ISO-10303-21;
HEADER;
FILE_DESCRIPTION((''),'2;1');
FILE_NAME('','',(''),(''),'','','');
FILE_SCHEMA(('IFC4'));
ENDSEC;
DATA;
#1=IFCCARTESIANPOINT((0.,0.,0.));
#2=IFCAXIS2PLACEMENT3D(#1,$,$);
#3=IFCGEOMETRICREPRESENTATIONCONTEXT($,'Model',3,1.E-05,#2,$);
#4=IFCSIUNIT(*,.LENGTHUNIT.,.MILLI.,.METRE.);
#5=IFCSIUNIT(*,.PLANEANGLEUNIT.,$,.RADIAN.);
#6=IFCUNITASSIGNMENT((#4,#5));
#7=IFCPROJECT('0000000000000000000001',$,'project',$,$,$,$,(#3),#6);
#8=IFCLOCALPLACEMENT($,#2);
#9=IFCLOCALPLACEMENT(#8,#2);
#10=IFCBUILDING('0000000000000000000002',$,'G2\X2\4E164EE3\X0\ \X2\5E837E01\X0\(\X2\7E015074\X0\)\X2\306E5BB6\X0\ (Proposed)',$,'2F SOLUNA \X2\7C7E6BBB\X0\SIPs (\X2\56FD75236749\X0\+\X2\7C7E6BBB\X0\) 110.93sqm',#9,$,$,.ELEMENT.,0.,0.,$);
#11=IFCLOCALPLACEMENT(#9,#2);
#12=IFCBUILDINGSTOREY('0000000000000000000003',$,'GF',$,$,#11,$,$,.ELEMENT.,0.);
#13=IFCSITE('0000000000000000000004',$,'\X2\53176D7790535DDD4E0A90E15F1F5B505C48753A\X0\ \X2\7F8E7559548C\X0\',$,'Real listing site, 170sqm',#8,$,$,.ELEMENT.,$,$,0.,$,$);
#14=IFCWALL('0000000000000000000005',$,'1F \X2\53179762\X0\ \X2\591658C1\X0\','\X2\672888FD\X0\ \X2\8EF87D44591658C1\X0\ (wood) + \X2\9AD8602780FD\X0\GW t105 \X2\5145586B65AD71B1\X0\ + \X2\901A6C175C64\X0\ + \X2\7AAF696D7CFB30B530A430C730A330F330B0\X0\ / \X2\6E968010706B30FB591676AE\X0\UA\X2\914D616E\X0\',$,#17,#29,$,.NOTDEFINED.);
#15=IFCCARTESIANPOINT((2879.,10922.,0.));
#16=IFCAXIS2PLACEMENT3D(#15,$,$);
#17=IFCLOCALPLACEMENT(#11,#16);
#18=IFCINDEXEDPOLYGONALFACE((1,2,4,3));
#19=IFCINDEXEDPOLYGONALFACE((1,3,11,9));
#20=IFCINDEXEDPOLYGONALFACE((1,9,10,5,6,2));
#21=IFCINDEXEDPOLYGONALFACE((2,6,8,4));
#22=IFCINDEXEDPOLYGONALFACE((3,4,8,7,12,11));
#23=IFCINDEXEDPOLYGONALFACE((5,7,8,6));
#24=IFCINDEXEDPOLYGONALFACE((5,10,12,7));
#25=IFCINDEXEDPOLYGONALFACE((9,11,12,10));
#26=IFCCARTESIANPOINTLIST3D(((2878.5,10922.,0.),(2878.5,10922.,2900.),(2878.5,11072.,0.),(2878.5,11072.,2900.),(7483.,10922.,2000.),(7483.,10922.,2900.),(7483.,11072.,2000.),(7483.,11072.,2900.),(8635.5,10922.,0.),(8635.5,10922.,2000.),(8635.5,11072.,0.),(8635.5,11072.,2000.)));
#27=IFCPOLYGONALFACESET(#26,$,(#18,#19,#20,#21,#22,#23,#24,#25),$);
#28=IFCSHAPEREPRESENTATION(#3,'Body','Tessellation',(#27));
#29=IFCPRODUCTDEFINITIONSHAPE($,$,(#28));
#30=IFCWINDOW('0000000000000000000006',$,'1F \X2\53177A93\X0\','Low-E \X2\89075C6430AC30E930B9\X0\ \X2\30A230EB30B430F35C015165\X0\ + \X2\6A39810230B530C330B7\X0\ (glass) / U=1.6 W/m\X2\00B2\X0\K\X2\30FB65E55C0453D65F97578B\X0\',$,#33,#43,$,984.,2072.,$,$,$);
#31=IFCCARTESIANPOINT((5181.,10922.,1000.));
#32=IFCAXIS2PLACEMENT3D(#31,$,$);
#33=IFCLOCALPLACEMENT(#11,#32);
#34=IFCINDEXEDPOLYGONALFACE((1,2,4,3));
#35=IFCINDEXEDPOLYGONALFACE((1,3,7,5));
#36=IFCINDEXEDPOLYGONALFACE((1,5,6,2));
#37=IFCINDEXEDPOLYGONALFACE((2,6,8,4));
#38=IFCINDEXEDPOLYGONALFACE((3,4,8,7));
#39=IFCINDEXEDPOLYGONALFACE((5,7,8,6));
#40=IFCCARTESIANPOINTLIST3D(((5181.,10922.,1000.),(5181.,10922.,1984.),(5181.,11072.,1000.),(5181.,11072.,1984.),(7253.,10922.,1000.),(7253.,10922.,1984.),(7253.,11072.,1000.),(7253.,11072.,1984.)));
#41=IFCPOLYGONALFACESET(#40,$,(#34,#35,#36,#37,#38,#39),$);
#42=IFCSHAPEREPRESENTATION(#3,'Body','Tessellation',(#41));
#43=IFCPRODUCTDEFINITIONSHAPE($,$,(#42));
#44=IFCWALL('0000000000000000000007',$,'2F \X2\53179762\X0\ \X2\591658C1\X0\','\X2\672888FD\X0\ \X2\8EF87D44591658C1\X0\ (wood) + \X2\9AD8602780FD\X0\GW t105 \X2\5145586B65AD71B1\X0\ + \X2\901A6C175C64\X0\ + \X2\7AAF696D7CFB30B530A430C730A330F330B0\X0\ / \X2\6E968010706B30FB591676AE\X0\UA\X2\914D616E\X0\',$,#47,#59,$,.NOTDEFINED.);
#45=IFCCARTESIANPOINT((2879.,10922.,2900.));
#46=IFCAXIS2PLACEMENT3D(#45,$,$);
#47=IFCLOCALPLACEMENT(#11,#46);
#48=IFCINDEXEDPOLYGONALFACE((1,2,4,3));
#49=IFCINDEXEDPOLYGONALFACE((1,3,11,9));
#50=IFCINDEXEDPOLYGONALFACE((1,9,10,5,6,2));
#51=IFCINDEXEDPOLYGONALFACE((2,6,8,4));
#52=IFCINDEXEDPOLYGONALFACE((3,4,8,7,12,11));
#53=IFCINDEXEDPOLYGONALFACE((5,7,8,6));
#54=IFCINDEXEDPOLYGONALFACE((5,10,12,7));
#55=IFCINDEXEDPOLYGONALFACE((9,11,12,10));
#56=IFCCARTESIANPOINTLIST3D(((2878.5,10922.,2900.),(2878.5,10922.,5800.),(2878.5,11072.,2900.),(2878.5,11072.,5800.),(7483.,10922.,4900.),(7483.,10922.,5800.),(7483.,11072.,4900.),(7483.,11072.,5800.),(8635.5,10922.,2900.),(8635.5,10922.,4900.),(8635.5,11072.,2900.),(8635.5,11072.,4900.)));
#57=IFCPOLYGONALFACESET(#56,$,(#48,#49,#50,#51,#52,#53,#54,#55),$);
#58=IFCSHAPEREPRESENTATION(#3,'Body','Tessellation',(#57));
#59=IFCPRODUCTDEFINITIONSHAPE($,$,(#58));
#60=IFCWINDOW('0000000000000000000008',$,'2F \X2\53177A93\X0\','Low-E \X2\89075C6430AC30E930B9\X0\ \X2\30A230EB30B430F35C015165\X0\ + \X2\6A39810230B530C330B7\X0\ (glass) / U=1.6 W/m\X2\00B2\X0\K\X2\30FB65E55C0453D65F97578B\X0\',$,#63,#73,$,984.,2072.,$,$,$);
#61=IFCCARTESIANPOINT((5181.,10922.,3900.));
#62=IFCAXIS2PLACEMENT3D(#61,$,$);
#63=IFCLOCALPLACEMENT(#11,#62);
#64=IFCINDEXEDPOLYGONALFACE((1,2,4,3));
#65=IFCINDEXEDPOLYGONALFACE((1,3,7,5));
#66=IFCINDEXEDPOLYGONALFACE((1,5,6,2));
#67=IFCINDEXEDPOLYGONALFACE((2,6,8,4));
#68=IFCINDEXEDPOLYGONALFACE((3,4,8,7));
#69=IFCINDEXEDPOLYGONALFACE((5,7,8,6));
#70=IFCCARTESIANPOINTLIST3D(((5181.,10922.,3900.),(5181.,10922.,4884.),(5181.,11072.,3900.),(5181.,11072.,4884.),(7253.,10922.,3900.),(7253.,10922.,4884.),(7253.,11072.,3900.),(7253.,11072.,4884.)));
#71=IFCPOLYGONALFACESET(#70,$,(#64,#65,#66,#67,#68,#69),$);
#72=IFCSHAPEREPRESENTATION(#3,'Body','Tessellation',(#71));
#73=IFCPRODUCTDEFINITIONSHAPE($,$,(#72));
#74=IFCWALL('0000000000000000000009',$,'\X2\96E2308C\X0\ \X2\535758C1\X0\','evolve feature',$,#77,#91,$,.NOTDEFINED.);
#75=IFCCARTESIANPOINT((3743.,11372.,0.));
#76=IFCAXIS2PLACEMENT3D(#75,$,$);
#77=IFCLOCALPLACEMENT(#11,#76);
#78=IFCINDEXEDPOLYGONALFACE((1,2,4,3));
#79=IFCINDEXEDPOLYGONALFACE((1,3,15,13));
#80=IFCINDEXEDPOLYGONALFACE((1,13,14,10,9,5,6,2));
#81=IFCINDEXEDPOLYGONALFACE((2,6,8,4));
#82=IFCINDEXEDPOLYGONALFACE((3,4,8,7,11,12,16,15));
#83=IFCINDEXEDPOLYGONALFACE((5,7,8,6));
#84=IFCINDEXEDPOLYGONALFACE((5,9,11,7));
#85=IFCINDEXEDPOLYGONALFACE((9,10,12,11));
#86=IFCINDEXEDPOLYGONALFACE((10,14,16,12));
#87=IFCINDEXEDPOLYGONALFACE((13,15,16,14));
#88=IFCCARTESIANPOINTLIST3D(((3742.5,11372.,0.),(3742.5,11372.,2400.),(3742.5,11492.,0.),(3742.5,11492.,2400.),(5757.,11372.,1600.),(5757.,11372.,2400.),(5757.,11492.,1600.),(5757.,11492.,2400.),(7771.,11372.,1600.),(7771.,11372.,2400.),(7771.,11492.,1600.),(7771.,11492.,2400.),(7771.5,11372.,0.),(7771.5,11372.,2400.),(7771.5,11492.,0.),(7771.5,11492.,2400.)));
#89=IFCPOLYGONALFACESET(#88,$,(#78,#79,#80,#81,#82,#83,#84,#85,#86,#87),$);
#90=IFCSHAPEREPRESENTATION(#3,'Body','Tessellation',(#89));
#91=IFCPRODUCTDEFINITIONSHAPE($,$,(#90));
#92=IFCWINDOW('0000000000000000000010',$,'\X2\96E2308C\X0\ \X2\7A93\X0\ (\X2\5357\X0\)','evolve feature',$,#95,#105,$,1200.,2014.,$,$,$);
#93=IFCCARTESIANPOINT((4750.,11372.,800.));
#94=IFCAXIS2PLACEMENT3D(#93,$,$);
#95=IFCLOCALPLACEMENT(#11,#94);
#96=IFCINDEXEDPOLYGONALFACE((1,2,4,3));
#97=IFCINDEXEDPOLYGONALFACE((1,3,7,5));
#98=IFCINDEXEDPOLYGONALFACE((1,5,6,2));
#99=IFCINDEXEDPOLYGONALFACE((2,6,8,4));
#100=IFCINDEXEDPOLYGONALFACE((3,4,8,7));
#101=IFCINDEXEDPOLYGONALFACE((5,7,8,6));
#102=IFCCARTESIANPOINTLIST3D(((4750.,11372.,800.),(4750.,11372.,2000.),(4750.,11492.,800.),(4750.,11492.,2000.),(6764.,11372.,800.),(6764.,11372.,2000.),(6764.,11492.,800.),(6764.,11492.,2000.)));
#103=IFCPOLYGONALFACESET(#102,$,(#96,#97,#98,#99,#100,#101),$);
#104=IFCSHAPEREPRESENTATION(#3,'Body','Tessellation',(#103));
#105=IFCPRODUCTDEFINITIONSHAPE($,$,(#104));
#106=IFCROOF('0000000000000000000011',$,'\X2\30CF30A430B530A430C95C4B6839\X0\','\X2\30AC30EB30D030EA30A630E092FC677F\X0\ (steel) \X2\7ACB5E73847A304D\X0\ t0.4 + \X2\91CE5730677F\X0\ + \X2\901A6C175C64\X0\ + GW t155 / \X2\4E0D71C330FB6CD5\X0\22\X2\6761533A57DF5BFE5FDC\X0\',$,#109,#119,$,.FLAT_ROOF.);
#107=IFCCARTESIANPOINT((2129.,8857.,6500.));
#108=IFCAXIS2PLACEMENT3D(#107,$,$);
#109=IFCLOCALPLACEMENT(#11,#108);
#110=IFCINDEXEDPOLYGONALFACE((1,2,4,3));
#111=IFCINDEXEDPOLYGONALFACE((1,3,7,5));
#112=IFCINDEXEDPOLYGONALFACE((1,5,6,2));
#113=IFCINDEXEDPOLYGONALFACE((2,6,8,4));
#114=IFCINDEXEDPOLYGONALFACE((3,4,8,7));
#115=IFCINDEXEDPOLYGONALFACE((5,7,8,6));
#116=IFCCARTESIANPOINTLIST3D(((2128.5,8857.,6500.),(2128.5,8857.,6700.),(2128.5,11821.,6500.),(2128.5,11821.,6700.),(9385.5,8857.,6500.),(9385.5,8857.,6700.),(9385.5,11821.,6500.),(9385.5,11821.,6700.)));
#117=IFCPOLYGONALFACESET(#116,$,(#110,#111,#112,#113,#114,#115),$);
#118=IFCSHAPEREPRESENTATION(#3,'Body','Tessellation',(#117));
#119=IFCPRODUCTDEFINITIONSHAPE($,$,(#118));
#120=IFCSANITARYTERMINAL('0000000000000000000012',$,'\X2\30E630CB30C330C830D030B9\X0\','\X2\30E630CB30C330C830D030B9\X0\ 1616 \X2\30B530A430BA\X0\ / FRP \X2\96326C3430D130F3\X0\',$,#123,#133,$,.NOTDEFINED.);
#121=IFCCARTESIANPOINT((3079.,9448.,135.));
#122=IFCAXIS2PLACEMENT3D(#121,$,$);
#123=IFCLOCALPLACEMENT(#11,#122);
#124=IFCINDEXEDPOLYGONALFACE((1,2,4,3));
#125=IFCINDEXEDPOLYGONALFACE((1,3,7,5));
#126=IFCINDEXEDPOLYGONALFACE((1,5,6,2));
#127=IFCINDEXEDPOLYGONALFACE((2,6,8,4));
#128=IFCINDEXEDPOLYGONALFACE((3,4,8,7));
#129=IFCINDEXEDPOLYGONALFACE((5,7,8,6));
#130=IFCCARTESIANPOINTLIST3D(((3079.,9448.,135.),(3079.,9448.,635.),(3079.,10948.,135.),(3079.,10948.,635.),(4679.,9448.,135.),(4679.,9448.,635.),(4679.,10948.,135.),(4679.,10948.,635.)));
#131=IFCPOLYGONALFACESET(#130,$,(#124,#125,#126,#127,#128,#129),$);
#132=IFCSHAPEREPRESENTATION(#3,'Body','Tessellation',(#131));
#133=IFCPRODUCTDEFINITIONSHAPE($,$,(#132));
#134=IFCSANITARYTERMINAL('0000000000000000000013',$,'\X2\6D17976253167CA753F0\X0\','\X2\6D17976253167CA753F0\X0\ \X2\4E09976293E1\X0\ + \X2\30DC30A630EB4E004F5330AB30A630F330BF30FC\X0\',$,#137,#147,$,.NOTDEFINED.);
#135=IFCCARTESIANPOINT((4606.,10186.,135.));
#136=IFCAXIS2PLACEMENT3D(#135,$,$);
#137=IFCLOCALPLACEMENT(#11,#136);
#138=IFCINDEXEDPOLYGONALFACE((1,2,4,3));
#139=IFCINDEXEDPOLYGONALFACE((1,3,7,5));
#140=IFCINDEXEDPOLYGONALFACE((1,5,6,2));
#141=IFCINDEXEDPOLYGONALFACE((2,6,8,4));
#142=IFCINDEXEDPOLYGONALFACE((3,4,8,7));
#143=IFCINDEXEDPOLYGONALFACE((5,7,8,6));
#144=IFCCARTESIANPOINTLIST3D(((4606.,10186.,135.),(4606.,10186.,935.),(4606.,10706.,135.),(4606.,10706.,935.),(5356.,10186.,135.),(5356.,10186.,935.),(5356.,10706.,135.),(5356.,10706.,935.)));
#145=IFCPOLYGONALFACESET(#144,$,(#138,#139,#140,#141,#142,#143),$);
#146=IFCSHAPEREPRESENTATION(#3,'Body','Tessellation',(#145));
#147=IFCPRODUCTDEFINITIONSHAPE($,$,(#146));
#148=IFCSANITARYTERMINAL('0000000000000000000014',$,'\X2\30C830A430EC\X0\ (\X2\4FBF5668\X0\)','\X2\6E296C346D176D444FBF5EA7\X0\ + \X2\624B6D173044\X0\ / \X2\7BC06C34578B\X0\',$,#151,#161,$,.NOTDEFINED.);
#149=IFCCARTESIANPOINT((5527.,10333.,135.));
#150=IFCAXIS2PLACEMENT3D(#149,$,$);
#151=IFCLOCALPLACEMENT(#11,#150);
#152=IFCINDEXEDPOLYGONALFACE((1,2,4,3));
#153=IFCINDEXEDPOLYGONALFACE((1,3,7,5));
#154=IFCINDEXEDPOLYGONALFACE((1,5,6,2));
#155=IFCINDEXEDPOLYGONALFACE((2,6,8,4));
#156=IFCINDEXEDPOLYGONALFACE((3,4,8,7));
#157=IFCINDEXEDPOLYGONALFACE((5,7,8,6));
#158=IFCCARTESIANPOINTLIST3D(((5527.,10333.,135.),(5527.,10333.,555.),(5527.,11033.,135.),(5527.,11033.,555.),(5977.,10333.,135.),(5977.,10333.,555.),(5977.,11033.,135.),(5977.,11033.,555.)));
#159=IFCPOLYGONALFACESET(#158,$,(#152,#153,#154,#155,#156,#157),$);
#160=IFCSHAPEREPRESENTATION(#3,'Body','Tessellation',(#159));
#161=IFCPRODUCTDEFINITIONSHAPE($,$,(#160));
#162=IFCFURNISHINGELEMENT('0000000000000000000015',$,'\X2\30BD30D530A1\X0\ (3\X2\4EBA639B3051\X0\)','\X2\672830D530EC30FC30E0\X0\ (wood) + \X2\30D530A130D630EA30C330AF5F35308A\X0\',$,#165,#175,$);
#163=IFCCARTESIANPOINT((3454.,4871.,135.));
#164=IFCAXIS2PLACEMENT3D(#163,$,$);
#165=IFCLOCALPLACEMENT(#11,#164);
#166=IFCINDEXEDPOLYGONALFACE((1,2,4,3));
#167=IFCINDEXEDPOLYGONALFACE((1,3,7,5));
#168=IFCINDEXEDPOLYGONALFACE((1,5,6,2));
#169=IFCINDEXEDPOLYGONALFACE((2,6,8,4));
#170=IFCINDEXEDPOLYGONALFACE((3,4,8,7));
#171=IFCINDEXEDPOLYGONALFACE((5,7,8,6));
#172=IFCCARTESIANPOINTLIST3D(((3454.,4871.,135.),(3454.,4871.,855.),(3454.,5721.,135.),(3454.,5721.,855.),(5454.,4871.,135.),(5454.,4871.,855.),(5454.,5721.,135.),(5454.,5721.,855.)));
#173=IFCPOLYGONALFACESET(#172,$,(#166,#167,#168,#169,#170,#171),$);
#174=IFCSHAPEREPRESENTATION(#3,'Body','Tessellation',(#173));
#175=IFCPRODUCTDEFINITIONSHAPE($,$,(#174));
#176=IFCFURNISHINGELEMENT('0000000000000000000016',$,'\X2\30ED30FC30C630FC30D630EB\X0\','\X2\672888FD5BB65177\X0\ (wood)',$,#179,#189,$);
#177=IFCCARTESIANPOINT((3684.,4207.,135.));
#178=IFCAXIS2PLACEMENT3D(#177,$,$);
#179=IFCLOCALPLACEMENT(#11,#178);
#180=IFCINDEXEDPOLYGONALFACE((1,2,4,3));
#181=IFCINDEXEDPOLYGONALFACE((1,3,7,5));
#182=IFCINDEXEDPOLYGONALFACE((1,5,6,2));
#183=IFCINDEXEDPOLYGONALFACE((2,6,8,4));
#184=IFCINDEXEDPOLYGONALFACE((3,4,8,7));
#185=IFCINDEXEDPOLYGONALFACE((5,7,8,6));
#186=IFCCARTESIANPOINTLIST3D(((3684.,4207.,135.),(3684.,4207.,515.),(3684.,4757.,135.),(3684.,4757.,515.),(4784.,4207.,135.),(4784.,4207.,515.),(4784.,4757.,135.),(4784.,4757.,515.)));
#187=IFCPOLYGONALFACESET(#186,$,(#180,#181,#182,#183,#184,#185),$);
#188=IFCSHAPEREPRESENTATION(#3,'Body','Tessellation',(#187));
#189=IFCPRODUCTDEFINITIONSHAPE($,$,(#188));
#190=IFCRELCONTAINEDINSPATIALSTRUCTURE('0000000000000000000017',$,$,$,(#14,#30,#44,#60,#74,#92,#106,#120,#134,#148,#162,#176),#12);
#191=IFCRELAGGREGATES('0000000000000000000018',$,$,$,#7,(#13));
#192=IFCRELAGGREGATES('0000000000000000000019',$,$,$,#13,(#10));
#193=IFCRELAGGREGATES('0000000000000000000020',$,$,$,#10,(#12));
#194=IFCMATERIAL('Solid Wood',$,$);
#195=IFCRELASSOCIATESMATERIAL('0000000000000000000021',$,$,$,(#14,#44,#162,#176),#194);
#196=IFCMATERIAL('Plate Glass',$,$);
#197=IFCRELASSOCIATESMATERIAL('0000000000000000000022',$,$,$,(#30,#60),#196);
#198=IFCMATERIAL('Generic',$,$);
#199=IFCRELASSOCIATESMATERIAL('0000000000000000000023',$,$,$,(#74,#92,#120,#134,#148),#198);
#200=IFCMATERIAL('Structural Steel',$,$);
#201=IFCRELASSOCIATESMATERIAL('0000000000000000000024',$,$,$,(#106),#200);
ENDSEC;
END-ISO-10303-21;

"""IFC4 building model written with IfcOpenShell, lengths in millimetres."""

from ifc_helpers import new_model, si_unit, frame, frame_2d, origin, place, context, project, spatial, rectangle, extrude, material, element, fill, save


model = new_model("IFC4")

# Units and contexts
model_context = context("Model", 3, precision=1e-05, world=origin())
ifc_project = project(units=[si_unit("LENGTHUNIT", "METRE", prefix="MILLI"), si_unit("PLANEANGLEUNIT", "RADIAN")], contexts=[model_context])

# Site, building, storey
site_placement = place(None, origin())
site = spatial("IfcSite", under=ifc_project, at=site_placement, Name="北海道川上郡弟子屈町 美留和", ObjectType="Real listing site, 170sqm", CompositionType="ELEMENT", RefElevation=0.0)
building_placement = place(site_placement, origin())
building = spatial("IfcBuilding", under=site, at=building_placement, Name="G2世代 広縁(縁側)の家 (Proposed)", ObjectType="2F SOLUNA 籾殻SIPs (国産杉+籾殻) 110.93sqm", CompositionType="ELEMENT", ElevationOfRefHeight=0.0, ElevationOfTerrain=0.0)
storey_placement = place(building_placement, origin())
storey = spatial("IfcBuildingStorey", under=building, at=storey_placement, Name="GF", CompositionType="ELEMENT", Elevation=0.0)

# Shared definitions
ifc_material_1 = material(Name="Generic")

# Wall, opening, window
ifc_material_2 = material(Name="Solid Wood")
wall_1_placement = place(storey_placement, frame((2879.0, 10922.0, 0.0)))
wall_1 = element("IfcWall", 1, at=wall_1_placement, inside=storey, material=ifc_material_2, Name="1F 北面 外壁", Description="木製 軸組外壁 (wood) + 高性能GW t105 充填断熱 + 通気層 + 窯業系サイディング / 準耐火・外皮UA配慮", PredefinedType="NOTDEFINED", context=model_context, shape_type="SweptSolid", body=[
    extrude(rectangle(XDim=5757.0, YDim=150.0, at=frame_2d((2878.0, 75.0))), frame((2879.0, 10922.0, 0.0)), (0.0, 0.0, 1.0), 2900.0),
])
opening_1_placement = place(storey_placement, frame((5181.0, 10922.0, 1000.0)))
opening_1 = element("IfcOpeningElement", 2, at=opening_1_placement, cuts=wall_1, PredefinedType="NOTDEFINED", context=model_context, shape_type="SweptSolid", body=[
    extrude(rectangle(XDim=2072.0, YDim=150.0, at=frame_2d((1036.0, 75.0))), frame((5181.0, 10922.0, 1000.0)), (0.0, 0.0, 1.0), 984.0),
])
ifc_material_3 = material(Name="Plate Glass")
window_1_placement = place(storey_placement, frame((5181.0, 10922.0, 1000.0)))
window_1 = element("IfcWindow", 3, at=window_1_placement, inside=storey, material=ifc_material_3, Name="1F 北窓", Description="Low-E 複層ガラス アルゴン封入 + 樹脂サッシ (glass) / U=1.6 W/m²K・日射取得型", OverallHeight=984.0, OverallWidth=2072.0, context=model_context, shape_type="SweptSolid", body=[
    extrude(rectangle(XDim=2072.0, YDim=150.0, at=frame_2d((1036.0, 75.0))), frame((5181.0, 10922.0, 1000.0)), (0.0, 0.0, 1.0), 984.0),
])
fill(opening_1, window_1)

# Wall, opening, window
wall_2_placement = place(storey_placement, frame((2879.0, 10922.0, 2900.0)))
wall_2 = element("IfcWall", 4, at=wall_2_placement, inside=storey, material=ifc_material_2, Name="2F 北面 外壁", Description="木製 軸組外壁 (wood) + 高性能GW t105 充填断熱 + 通気層 + 窯業系サイディング / 準耐火・外皮UA配慮", PredefinedType="NOTDEFINED", context=model_context, shape_type="SweptSolid", body=[
    extrude(rectangle(XDim=5757.0, YDim=150.0, at=frame_2d((2878.0, 75.0))), frame((2879.0, 10922.0, 2900.0)), (0.0, 0.0, 1.0), 2900.0),
])
opening_2_placement = place(storey_placement, frame((5181.0, 10922.0, 3900.0)))
opening_2 = element("IfcOpeningElement", 5, at=opening_2_placement, cuts=wall_2, PredefinedType="NOTDEFINED", context=model_context, shape_type="SweptSolid", body=[
    extrude(rectangle(XDim=2072.0, YDim=150.0, at=frame_2d((1036.0, 75.0))), frame((5181.0, 10922.0, 3900.0)), (0.0, 0.0, 1.0), 984.0),
])
window_2_placement = place(storey_placement, frame((5181.0, 10922.0, 3900.0)))
window_2 = element("IfcWindow", 6, at=window_2_placement, inside=storey, material=ifc_material_3, Name="2F 北窓", Description="Low-E 複層ガラス アルゴン封入 + 樹脂サッシ (glass) / U=1.6 W/m²K・日射取得型", OverallHeight=984.0, OverallWidth=2072.0, context=model_context, shape_type="SweptSolid", body=[
    extrude(rectangle(XDim=2072.0, YDim=150.0, at=frame_2d((1036.0, 75.0))), frame((5181.0, 10922.0, 3900.0)), (0.0, 0.0, 1.0), 984.0),
])
fill(opening_2, window_2)

# Wall, opening, window
wall_3_placement = place(storey_placement, frame((3743.0, 11372.0, 0.0)))
wall_3 = element("IfcWall", 7, at=wall_3_placement, inside=storey, material=ifc_material_1, Name="離れ 南壁", Description="evolve feature", PredefinedType="NOTDEFINED", context=model_context, shape_type="SweptSolid", body=[
    extrude(rectangle(XDim=4029.0, YDim=120.0, at=frame_2d((2014.0, 60.0))), frame((3743.0, 11372.0, 0.0)), (0.0, 0.0, 1.0), 2400.0),
])
opening_3_placement = place(storey_placement, frame((4750.0, 11372.0, 800.0)))
opening_3 = element("IfcOpeningElement", 8, at=opening_3_placement, cuts=wall_3, PredefinedType="NOTDEFINED", context=model_context, shape_type="SweptSolid", body=[
    extrude(rectangle(XDim=2014.0, YDim=120.0, at=frame_2d((1007.0, 60.0))), frame((4750.0, 11372.0, 800.0)), (0.0, 0.0, 1.0), 1200.0),
])
window_3_placement = place(storey_placement, frame((4750.0, 11372.0, 800.0)))
window_3 = element("IfcWindow", 9, at=window_3_placement, inside=storey, material=ifc_material_1, Name="離れ 窓 (南)", Description="evolve feature", OverallHeight=1200.0, OverallWidth=2014.0, context=model_context, shape_type="SweptSolid", body=[
    extrude(rectangle(XDim=2014.0, YDim=120.0, at=frame_2d((1007.0, 60.0))), frame((4750.0, 11372.0, 800.0)), (0.0, 0.0, 1.0), 1200.0),
])
fill(opening_3, window_3)

# Roof
ifc_material_4 = material(Name="Structural Steel")
roof_1_placement = place(storey_placement, frame((2129.0, 8857.0, 6500.0)))
element("IfcRoof", 10, at=roof_1_placement, inside=storey, material=ifc_material_4, Name="ハイサイド屋根", Description="ガルバリウム鋼板 (steel) 立平葺き t0.4 + 野地板 + 通気層 + GW t155 / 不燃・法22条区域対応", PredefinedType="FLAT_ROOF", context=model_context, shape_type="SweptSolid", body=[
    extrude(rectangle(XDim=7257.0, YDim=2964.0, at=frame_2d((3628.0, 1482.0))), frame((2129.0, 8857.0, 6500.0)), (0.0, 0.0, 1.0), 200.0),
])

# Sanitary terminals
sanitary_terminal_1_placement = place(storey_placement, frame((3079.0, 9448.0, 135.0)))
element("IfcSanitaryTerminal", 11, at=sanitary_terminal_1_placement, inside=storey, material=ifc_material_1, Name="ユニットバス", Description="ユニットバス 1616 サイズ / FRP 防水パン", PredefinedType="NOTDEFINED", context=model_context, shape_type="SweptSolid", body=[
    extrude(rectangle(XDim=1600.0, YDim=1500.0, at=frame_2d((800.0, 750.0))), frame((3079.0, 9448.0, 135.0)), (0.0, 0.0, 1.0), 500.0),
])
sanitary_terminal_2_placement = place(storey_placement, frame((4606.0, 10186.0, 135.0)))
element("IfcSanitaryTerminal", 12, at=sanitary_terminal_2_placement, inside=storey, material=ifc_material_1, Name="洗面化粧台", Description="洗面化粧台 三面鏡 + ボウル一体カウンター", PredefinedType="NOTDEFINED", context=model_context, shape_type="SweptSolid", body=[
    extrude(rectangle(XDim=750.0, YDim=520.0, at=frame_2d((375.0, 260.0))), frame((4606.0, 10186.0, 135.0)), (0.0, 0.0, 1.0), 800.0),
])
sanitary_terminal_3_placement = place(storey_placement, frame((5527.0, 10333.0, 135.0)))
element("IfcSanitaryTerminal", 13, at=sanitary_terminal_3_placement, inside=storey, material=ifc_material_1, Name="トイレ (便器)", Description="温水洗浄便座 + 手洗い / 節水型", PredefinedType="NOTDEFINED", context=model_context, shape_type="SweptSolid", body=[
    extrude(rectangle(XDim=450.0, YDim=700.0, at=frame_2d((225.0, 350.0))), frame((5527.0, 10333.0, 135.0)), (0.0, 0.0, 1.0), 420.0),
])

# Furnishing elements
furnishing_1_placement = place(storey_placement, frame((3454.0, 4871.0, 135.0)))
element("IfcFurnishingElement", 14, at=furnishing_1_placement, inside=storey, material=ifc_material_2, Name="ソファ (3人掛け)", Description="木フレーム (wood) + ファブリック張り", context=model_context, shape_type="SweptSolid", body=[
    extrude(rectangle(XDim=2000.0, YDim=850.0, at=frame_2d((1000.0, 425.0))), frame((3454.0, 4871.0, 135.0)), (0.0, 0.0, 1.0), 720.0),
])
furnishing_2_placement = place(storey_placement, frame((3684.0, 4207.0, 135.0)))
element("IfcFurnishingElement", 15, at=furnishing_2_placement, inside=storey, material=ifc_material_2, Name="ローテーブル", Description="木製家具 (wood)", context=model_context, shape_type="SweptSolid", body=[
    extrude(rectangle(XDim=1100.0, YDim=550.0, at=frame_2d((550.0, 275.0))), frame((3684.0, 4207.0, 135.0)), (0.0, 0.0, 1.0), 380.0),
])

save(model, "model.ifc")
